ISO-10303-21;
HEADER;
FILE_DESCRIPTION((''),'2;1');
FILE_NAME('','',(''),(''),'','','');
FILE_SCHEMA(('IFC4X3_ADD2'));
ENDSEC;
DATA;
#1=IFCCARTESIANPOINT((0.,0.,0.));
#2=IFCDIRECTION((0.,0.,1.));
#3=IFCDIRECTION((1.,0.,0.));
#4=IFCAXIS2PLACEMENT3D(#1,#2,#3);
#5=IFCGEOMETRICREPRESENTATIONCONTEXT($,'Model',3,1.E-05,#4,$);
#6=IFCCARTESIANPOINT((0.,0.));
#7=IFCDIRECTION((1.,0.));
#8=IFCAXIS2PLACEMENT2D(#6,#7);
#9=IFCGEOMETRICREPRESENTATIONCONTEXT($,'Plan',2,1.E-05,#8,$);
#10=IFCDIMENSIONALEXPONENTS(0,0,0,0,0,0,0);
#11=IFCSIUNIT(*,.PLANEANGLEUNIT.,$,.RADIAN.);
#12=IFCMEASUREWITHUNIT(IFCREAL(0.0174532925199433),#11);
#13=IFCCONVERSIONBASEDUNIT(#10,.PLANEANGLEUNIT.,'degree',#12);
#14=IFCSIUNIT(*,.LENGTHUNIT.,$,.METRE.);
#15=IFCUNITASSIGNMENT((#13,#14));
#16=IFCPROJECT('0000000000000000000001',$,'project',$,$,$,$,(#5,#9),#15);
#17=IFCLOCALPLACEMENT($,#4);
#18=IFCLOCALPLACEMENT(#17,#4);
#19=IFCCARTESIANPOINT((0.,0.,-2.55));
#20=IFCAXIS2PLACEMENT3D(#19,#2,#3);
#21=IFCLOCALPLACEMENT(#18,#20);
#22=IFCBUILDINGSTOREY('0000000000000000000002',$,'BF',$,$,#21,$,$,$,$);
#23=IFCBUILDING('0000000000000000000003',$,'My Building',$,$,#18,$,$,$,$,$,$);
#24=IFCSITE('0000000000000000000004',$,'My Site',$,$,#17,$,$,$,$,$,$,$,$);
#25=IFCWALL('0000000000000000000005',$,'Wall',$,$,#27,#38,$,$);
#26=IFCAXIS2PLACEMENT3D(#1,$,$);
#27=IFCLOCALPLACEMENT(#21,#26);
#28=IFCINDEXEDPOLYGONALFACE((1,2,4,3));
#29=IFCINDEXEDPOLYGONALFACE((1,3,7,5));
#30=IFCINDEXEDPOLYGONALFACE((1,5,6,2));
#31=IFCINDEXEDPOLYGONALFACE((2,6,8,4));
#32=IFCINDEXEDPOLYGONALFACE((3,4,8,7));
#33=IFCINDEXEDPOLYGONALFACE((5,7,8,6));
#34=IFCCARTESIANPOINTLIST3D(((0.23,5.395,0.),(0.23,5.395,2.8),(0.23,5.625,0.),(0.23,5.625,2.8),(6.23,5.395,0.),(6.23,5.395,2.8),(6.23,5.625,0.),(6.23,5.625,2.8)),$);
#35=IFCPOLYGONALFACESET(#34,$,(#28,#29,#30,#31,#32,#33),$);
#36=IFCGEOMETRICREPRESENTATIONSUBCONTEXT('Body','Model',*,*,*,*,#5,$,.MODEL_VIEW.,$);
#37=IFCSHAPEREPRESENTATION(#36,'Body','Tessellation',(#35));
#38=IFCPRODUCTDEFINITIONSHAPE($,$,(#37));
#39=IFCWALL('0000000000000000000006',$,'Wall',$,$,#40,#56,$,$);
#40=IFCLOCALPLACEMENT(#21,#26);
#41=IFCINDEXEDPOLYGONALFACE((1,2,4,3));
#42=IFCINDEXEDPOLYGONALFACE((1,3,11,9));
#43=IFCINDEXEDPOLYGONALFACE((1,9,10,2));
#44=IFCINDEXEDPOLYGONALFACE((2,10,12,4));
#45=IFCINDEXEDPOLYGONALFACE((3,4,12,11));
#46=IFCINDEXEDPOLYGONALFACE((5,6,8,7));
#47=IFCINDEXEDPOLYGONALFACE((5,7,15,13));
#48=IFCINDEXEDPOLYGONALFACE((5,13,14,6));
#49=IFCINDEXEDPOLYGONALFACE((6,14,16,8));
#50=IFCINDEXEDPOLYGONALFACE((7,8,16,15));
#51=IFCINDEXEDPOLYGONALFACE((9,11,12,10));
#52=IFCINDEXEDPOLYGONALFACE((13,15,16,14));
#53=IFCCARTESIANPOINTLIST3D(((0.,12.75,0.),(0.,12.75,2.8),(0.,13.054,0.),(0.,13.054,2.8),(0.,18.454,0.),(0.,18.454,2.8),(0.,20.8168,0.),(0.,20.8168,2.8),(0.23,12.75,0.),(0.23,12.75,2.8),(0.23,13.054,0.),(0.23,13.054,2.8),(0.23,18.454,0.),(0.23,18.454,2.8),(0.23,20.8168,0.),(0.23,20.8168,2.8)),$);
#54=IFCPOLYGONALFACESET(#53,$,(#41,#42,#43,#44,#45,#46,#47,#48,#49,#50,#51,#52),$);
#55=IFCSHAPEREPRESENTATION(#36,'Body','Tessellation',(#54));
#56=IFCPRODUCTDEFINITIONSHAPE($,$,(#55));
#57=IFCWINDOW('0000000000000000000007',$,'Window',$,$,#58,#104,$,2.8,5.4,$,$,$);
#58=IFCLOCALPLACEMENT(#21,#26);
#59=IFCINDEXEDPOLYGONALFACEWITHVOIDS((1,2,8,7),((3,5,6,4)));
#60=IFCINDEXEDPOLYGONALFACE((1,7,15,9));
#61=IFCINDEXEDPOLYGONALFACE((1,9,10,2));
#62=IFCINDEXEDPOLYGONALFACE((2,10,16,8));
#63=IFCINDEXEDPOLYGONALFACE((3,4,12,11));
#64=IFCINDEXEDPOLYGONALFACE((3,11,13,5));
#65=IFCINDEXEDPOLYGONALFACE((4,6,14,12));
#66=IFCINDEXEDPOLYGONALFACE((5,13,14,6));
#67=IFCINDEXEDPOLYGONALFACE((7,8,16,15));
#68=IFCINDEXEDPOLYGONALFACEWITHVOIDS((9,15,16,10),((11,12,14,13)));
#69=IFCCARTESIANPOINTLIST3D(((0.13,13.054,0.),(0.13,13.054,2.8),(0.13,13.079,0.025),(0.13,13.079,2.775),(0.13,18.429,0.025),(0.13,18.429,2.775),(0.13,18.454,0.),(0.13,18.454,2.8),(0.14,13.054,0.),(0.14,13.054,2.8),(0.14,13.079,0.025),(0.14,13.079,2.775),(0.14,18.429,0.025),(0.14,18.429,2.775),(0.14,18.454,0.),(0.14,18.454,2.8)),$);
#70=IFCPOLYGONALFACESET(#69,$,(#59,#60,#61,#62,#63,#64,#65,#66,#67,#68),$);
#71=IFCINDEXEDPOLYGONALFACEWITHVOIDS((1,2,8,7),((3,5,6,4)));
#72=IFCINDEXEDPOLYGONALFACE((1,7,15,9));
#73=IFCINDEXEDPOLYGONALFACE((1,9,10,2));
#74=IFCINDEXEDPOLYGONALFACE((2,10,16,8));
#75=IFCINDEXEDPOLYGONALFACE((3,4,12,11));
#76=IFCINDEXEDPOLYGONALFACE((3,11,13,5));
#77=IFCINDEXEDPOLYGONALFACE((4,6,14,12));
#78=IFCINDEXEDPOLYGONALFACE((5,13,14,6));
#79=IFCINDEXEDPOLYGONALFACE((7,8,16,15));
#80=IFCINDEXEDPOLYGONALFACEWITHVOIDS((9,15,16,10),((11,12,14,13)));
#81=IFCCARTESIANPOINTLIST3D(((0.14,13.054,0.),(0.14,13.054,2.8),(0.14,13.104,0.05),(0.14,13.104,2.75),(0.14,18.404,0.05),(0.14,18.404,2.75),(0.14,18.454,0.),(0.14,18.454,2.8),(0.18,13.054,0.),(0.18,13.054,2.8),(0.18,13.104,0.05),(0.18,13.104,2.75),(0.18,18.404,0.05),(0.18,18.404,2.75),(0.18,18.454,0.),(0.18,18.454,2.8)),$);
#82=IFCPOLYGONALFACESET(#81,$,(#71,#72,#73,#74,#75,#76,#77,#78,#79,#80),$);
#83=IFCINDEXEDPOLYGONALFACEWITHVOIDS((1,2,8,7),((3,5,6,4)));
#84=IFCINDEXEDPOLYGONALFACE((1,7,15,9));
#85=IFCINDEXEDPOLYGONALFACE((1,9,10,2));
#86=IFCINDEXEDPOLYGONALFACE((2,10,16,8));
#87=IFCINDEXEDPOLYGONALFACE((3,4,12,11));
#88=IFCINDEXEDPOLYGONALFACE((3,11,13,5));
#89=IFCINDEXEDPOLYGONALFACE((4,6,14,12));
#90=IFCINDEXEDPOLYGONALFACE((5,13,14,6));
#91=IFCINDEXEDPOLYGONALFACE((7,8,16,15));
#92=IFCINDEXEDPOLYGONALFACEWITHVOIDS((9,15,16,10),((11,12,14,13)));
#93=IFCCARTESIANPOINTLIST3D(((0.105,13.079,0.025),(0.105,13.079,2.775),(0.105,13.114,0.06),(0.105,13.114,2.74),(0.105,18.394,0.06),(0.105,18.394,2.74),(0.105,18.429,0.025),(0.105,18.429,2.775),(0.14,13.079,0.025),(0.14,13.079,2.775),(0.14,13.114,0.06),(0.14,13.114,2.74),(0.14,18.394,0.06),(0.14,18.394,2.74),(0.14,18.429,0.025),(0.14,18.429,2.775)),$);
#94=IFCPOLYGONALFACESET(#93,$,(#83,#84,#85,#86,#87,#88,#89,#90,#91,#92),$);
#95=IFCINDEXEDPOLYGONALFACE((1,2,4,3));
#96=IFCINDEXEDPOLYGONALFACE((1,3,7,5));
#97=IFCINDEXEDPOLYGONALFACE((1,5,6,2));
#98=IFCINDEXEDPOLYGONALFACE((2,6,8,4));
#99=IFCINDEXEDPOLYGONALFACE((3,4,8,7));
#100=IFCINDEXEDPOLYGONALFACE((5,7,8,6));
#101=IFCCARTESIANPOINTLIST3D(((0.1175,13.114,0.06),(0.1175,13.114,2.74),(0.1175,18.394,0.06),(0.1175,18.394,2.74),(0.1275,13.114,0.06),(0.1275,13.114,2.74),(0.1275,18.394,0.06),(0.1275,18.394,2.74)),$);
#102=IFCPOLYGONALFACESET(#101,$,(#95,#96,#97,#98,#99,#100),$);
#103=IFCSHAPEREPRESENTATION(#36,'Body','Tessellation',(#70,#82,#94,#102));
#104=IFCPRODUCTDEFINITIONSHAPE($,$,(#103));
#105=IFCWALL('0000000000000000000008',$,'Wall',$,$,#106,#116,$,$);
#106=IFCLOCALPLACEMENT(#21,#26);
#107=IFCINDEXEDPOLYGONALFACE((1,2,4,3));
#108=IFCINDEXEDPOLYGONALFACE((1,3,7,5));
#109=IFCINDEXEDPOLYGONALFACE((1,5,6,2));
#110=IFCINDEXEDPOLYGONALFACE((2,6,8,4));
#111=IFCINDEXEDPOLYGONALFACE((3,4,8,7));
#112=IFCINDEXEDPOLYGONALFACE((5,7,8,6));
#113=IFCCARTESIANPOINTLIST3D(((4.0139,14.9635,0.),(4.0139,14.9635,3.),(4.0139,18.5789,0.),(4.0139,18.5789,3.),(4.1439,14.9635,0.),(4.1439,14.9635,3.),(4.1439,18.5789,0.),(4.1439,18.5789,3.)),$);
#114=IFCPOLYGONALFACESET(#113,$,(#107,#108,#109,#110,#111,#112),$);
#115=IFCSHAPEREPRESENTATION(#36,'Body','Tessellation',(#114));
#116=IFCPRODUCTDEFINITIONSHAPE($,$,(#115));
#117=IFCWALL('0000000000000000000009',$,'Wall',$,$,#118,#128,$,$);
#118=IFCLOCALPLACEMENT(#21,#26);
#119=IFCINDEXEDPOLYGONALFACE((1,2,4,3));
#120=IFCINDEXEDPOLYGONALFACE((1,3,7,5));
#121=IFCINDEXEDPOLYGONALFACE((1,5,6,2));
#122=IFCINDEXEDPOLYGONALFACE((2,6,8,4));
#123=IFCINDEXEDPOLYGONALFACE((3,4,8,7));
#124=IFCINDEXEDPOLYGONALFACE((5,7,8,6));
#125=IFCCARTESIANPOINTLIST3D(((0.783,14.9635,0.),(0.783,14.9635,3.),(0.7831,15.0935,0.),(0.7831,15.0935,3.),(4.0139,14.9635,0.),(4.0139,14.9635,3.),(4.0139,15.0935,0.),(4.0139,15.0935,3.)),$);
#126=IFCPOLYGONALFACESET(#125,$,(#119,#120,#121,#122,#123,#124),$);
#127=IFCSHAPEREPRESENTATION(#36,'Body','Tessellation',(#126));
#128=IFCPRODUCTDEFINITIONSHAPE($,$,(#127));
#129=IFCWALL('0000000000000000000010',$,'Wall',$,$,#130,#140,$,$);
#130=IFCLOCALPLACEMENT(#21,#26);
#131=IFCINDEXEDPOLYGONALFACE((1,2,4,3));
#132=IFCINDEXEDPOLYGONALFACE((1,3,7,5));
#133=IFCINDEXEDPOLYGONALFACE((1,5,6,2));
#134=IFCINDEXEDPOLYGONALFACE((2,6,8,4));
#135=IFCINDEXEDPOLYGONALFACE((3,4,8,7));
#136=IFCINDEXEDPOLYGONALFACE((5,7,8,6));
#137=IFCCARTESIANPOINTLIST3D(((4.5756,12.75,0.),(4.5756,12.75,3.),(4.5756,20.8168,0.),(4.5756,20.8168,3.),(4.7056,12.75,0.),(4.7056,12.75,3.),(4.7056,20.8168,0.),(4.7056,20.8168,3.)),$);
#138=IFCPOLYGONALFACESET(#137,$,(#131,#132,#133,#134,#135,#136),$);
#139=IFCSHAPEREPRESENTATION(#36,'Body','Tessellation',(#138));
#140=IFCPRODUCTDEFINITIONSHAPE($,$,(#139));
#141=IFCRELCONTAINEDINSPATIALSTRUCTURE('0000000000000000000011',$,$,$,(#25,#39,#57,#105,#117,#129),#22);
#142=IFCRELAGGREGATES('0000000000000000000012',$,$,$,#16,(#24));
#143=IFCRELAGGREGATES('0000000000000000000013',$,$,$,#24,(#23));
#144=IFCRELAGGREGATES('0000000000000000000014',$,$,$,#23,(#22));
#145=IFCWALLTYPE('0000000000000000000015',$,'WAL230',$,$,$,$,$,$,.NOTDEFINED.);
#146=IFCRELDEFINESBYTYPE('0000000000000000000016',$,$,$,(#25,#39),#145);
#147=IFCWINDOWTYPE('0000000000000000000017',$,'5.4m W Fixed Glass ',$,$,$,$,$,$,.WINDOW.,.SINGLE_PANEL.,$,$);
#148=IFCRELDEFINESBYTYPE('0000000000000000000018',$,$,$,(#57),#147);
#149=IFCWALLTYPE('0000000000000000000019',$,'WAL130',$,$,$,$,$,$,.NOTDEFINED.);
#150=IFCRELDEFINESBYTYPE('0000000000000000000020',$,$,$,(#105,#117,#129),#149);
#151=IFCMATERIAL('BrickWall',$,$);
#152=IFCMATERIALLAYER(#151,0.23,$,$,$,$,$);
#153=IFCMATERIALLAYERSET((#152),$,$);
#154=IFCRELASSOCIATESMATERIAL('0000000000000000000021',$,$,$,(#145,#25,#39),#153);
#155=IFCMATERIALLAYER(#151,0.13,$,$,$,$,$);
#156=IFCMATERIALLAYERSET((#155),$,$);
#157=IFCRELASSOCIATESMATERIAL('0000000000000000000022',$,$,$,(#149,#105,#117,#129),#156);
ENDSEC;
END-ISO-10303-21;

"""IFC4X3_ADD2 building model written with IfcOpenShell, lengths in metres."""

from ifc_helpers import new_model, entity, si_unit, converted_unit, frame, origin_with_axes, origin_2d_with_axis, place, context, subcontext, project, spatial, line, indexed_curve, outline, extrude, shape, source, transform, mapped, material, layer, layer_set, layer_usage, type_object, type_shapes, element, fill, save


model = new_model("IFC4X3_ADD2")

# Units and contexts
model_context = context("Model", 3, precision=1e-05, world=origin_with_axes())
plan_context = context("Plan", 2, precision=1e-05, world=origin_2d_with_axis())
body_context_1 = subcontext(model_context, "Body", "Model", "MODEL_VIEW")
body_context_2 = subcontext(plan_context, "Body", "Plan", "PLAN_VIEW")
ifc_project = project(units=[converted_unit("PLANEANGLEUNIT", "degree", entity("IfcReal", 0.0174532925199433), si_unit("PLANEANGLEUNIT", "RADIAN"), dimensions=[0, 0, 0, 0, 0, 0, 0]), si_unit("LENGTHUNIT", "METRE")], contexts=[model_context, plan_context])

# Site, building, storey
site_placement = place(None, origin_with_axes())
site = spatial("IfcSite", under=ifc_project, at=site_placement, Name="My Site")
building_placement = place(site_placement, origin_with_axes())
building = spatial("IfcBuilding", under=site, at=building_placement, Name="My Building")
storey_placement = place(building_placement, frame((0.0, 0.0, -2.55), z_axis=(0.0, 0.0, 1.0), x_axis=(1.0, 0.0, 0.0)))
storey = spatial("IfcBuildingStorey", under=building, at=storey_placement, Name="BF")

# Shared definitions
ifc_material_1 = material(Name="BrickWall")

# Shared definitions
ifc_layer_1 = layer(ifc_material_1, 0.23)
ifc_layer_set_1 = layer_set([ifc_layer_1])
wall_type_1 = type_object("IfcWallType", Name="WAL230", PredefinedType="NOTDEFINED", material=ifc_layer_set_1)
shared_shape_1 = source(origin_with_axes(), body_context_1, "Body", "SweptSolid", [
    extrude(outline(indexed_curve([(0.0, 0.0), (5.4, 0.0), (5.4, 2.8), (0.0, 2.8)], segments=[line(1, 2, 3, 4, 1)])), frame((0.0, -0.6, 0.0), z_axis=(0.0, -1.0, 0.0), x_axis=(1.0, 0.0, 0.0)), (0.0, 0.0, -1.0), 1.2),
])
window_type_1 = type_object("IfcWindowType", Name="5.4m W Fixed Glass ", PartitioningType="SINGLE_PANEL", PredefinedType="WINDOW")
shared_shape_2 = source(origin_with_axes(), body_context_1, "Body", "SweptSolid", [
    extrude(outline(indexed_curve([(0.0, 0.0), (5.4, 0.0), (5.4, 2.8), (0.0, 2.8)], segments=[line(1, 2, 3, 4, 1)]), holes=[indexed_curve([(0.025, 0.025), (5.375, 0.025), (5.375, 2.775), (0.025, 2.775)], segments=[line(1, 2, 3, 4, 1)])]), frame((0.0, 0.09, 0.0), z_axis=(0.0, -1.0, 0.0), x_axis=(1.0, 0.0, 0.0)), (0.0, 0.0, -1.0), 0.01),
    extrude(outline(indexed_curve([(0.0, 0.0), (5.4, 0.0), (5.4, 2.8), (0.0, 2.8)], segments=[line(1, 2, 3, 4, 1)]), holes=[indexed_curve([(0.05, 0.05), (5.35, 0.05), (5.35, 2.75), (0.05, 2.75)], segments=[line(1, 2, 3, 4, 1)])]), frame((0.0, 0.05, 0.0), z_axis=(0.0, -1.0, 0.0), x_axis=(1.0, 0.0, 0.0)), (0.0, 0.0, -1.0), 0.04),
    extrude(outline(indexed_curve([(0.0, 0.0), (5.35, 0.0), (5.35, 2.75), (0.0, 2.75)], segments=[line(1, 2, 3, 4, 1)]), holes=[indexed_curve([(0.035, 0.035), (5.315, 0.035), (5.315, 2.715), (0.035, 2.715)], segments=[line(1, 2, 3, 4, 1)])]), frame((0.025, 0.09, 0.025), z_axis=(0.0, -1.0, 0.0), x_axis=(1.0, 0.0, 0.0)), (0.0, 0.0, -1.0), 0.035),
    extrude(outline(indexed_curve([(0.035, 0.035), (5.315, 0.035), (5.315, 2.715), (0.035, 2.715)], segments=[line(1, 2, 3, 4, 1)])), frame((0.025, 0.1025, 0.025), z_axis=(0.0, -1.0, 0.0), x_axis=(1.0, 0.0, 0.0)), (0.0, 0.0, -1.0), 0.01),
])
shared_shape_3 = source(origin_with_axes(), body_context_2, "Body", "Curve2D", [
    entity("IfcIndexedPolyCurve", entity("IfcCartesianPointList2D", [[0.05, 0.05], [5.35, 0.05]])),
    entity("IfcIndexedPolyCurve", entity("IfcCartesianPointList2D", [[0.0, 0.1], [0.025, 0.1], [0.025, 0.09], [0.05, 0.09], [0.05, 0.05], [0.0, 0.05]]), [entity("IfcLineIndex", [1, 2, 3, 4, 5, 6, 1])]),
    entity("IfcIndexedPolyCurve", entity("IfcCartesianPointList2D", [[5.4, 0.1], [5.375, 0.1], [5.375, 0.09], [5.35, 0.09], [5.35, 0.05], [5.4, 0.05]]), [entity("IfcLineIndex", [1, 2, 3, 4, 5, 6, 1])]),
    entity("IfcIndexedPolyCurve", entity("IfcCartesianPointList2D", [[0.025, 0.09], [0.06, 0.09], [0.06, 0.125], [0.025, 0.125]]), [entity("IfcLineIndex", [1, 2, 3, 4, 1])]),
    entity("IfcIndexedPolyCurve", entity("IfcCartesianPointList2D", [[5.375, 0.09], [5.34, 0.09], [5.34, 0.125], [5.375, 0.125]]), [entity("IfcLineIndex", [1, 2, 3, 4, 1])]),
    entity("IfcIndexedPolyCurve", entity("IfcCartesianPointList2D", [[0.06, 0.09], [5.34, 0.09]])),
    entity("IfcIndexedPolyCurve", entity("IfcCartesianPointList2D", [[0.06, 0.125], [5.34, 0.125]])),
    entity("IfcIndexedPolyCurve", entity("IfcCartesianPointList2D", [[0.06, 0.1075], [5.34, 0.1075]])),
])
type_shapes(window_type_1, [shared_shape_2, shared_shape_3])

# Wall
ifc_layer_usage_1 = layer_usage(ifc_layer_set_1, "AXIS2", "POSITIVE", 0.0)
wall_1_placement = place(storey_placement, frame((0.23, 5.395, 0.0), z_axis=(0.0, 0.0, 1.0), x_axis=(1.0, 0.0, 0.0)))
element("IfcWall", 1, at=wall_1_placement, inside=storey, type_object=wall_type_1, material=ifc_layer_usage_1, Name="Wall", context=body_context_1, shape_type="SweptSolid", body=[
    extrude(outline(indexed_curve([(0.0, 0.0), (0.0, 0.23), (6.0, 0.23), (6.0, 0.0), (0.0, 0.0)], self_intersect=False)), origin_with_axes(), (0.0, 0.0, 1.0), 2.8),
])

# Wall, opening, window
ifc_layer_usage_2 = layer_usage(ifc_layer_set_1, "AXIS2", "POSITIVE", 0.0)
wall_2_placement = place(storey_placement, frame((0.23, 12.75, 0.0), z_axis=(0.0, 0.0, 1.0), x_axis=(0.0, 1.0, 0.0)))
wall_2 = element("IfcWall", 2, at=wall_2_placement, inside=storey, type_object=wall_type_1, material=ifc_layer_usage_2, Name="Wall", context=body_context_1, shape_type="SweptSolid", body=[
    extrude(outline(indexed_curve([(0.0, 0.0), (0.0, 0.23), (8.0668, 0.23), (8.0668, 0.0), (0.0, 0.0)], self_intersect=False)), origin_with_axes(), (0.0, 0.0, 1.0), 2.8),
])
opening_1_placement = place(wall_2_placement, frame((0.304, 0.0, 0.0), z_axis=(0.0, 0.0, 1.0), x_axis=(1.0, 0.0, 0.0)))
opening_1 = element("IfcOpeningElement", 3, at=opening_1_placement, cuts=wall_2, PredefinedType="OPENING", context=body_context_1, shape_type="MappedRepresentation", body=[
    mapped(shared_shape_1, transform((0.0, 0.0, 0.0), x_axis=(1.0, 0.0, 0.0), y_axis=(0.0, 1.0, 0.0), z_axis=(0.0, 0.0, 1.0), scale=1.0)),
])
window_1_placement = place(opening_1_placement, frame((0.0, 0.0, 0.0), z_axis=(0.0, 0.0, 1.0), x_axis=(1.0, 0.0, 0.0)))
window_1 = element("IfcWindow", 4, at=window_1_placement, inside=storey, type_object=window_type_1, Name="Window", OverallHeight=2.8, OverallWidth=5.4, shapes=[
    shape(body_context_1, "Body", "MappedRepresentation", [mapped(shared_shape_2, transform((0.0, 0.0, 0.0), x_axis=(1.0, 0.0, 0.0), y_axis=(0.0, 1.0, 0.0), z_axis=(0.0, 0.0, 1.0), scale=1.0))]),
    shape(body_context_2, "Body", "MappedRepresentation", [mapped(shared_shape_3, transform((0.0, 0.0, 0.0), x_axis=(1.0, 0.0, 0.0), y_axis=(0.0, 1.0, 0.0), z_axis=(0.0, 0.0, 1.0), scale=1.0))]),
])
fill(opening_1, window_1)

# Walls
ifc_layer_2 = layer(ifc_material_1, 0.13)
ifc_layer_set_2 = layer_set([ifc_layer_2])
ifc_layer_usage_3 = layer_usage(ifc_layer_set_2, "AXIS2", "POSITIVE", 0.0)
wall_type_2 = type_object("IfcWallType", Name="WAL130", PredefinedType="NOTDEFINED", material=ifc_layer_set_2)
wall_3_placement = place(storey_placement, frame((4.1439, 14.9635, 0.0), z_axis=(0.0, 0.0, 1.0), x_axis=(0.0, 1.0, 0.0)))
element("IfcWall", 5, at=wall_3_placement, inside=storey, type_object=wall_type_2, material=ifc_layer_usage_3, Name="Wall", context=body_context_1, shape_type="SweptSolid", body=[
    extrude(outline(indexed_curve([(0.0, 0.0), (0.0, 0.13), (3.6154, 0.13), (3.6154, 0.0), (0.0, 0.0)], self_intersect=False)), origin_with_axes(), (0.0, 0.0, 1.0), 3.0),
])
ifc_layer_usage_4 = layer_usage(ifc_layer_set_2, "AXIS2", "POSITIVE", 0.0)
wall_4_placement = place(storey_placement, frame((4.0139, 15.0935, 0.0), z_axis=(0.0, 0.0, 1.0), x_axis=(-1.0, 0.0, 0.0)))
element("IfcWall", 6, at=wall_4_placement, inside=storey, type_object=wall_type_2, material=ifc_layer_usage_4, Name="Wall", context=body_context_1, shape_type="SweptSolid", body=[
    extrude(outline(indexed_curve([(0.0, 0.0), (0.0, 0.13), (3.2309, 0.13), (3.2309, 0.0), (0.0, 0.0)], self_intersect=False)), origin_with_axes(), (0.0, 0.0, 1.0), 3.0),
])
ifc_layer_usage_5 = layer_usage(ifc_layer_set_2, "AXIS2", "POSITIVE", 0.0)
wall_5_placement = place(storey_placement, frame((4.7056, 12.75, 0.0), z_axis=(0.0, 0.0, 1.0), x_axis=(0.0, 1.0, 0.0)))
element("IfcWall", 7, at=wall_5_placement, inside=storey, type_object=wall_type_2, material=ifc_layer_usage_5, Name="Wall", context=body_context_1, shape_type="SweptSolid", body=[
    extrude(outline(indexed_curve([(0.0, 0.0), (0.0, 0.13), (8.0668, 0.13), (8.0668, 0.0), (0.0, 0.0)], self_intersect=False)), origin_with_axes(), (0.0, 0.0, 1.0), 3.0),
])

save(model, "model.ifc")
